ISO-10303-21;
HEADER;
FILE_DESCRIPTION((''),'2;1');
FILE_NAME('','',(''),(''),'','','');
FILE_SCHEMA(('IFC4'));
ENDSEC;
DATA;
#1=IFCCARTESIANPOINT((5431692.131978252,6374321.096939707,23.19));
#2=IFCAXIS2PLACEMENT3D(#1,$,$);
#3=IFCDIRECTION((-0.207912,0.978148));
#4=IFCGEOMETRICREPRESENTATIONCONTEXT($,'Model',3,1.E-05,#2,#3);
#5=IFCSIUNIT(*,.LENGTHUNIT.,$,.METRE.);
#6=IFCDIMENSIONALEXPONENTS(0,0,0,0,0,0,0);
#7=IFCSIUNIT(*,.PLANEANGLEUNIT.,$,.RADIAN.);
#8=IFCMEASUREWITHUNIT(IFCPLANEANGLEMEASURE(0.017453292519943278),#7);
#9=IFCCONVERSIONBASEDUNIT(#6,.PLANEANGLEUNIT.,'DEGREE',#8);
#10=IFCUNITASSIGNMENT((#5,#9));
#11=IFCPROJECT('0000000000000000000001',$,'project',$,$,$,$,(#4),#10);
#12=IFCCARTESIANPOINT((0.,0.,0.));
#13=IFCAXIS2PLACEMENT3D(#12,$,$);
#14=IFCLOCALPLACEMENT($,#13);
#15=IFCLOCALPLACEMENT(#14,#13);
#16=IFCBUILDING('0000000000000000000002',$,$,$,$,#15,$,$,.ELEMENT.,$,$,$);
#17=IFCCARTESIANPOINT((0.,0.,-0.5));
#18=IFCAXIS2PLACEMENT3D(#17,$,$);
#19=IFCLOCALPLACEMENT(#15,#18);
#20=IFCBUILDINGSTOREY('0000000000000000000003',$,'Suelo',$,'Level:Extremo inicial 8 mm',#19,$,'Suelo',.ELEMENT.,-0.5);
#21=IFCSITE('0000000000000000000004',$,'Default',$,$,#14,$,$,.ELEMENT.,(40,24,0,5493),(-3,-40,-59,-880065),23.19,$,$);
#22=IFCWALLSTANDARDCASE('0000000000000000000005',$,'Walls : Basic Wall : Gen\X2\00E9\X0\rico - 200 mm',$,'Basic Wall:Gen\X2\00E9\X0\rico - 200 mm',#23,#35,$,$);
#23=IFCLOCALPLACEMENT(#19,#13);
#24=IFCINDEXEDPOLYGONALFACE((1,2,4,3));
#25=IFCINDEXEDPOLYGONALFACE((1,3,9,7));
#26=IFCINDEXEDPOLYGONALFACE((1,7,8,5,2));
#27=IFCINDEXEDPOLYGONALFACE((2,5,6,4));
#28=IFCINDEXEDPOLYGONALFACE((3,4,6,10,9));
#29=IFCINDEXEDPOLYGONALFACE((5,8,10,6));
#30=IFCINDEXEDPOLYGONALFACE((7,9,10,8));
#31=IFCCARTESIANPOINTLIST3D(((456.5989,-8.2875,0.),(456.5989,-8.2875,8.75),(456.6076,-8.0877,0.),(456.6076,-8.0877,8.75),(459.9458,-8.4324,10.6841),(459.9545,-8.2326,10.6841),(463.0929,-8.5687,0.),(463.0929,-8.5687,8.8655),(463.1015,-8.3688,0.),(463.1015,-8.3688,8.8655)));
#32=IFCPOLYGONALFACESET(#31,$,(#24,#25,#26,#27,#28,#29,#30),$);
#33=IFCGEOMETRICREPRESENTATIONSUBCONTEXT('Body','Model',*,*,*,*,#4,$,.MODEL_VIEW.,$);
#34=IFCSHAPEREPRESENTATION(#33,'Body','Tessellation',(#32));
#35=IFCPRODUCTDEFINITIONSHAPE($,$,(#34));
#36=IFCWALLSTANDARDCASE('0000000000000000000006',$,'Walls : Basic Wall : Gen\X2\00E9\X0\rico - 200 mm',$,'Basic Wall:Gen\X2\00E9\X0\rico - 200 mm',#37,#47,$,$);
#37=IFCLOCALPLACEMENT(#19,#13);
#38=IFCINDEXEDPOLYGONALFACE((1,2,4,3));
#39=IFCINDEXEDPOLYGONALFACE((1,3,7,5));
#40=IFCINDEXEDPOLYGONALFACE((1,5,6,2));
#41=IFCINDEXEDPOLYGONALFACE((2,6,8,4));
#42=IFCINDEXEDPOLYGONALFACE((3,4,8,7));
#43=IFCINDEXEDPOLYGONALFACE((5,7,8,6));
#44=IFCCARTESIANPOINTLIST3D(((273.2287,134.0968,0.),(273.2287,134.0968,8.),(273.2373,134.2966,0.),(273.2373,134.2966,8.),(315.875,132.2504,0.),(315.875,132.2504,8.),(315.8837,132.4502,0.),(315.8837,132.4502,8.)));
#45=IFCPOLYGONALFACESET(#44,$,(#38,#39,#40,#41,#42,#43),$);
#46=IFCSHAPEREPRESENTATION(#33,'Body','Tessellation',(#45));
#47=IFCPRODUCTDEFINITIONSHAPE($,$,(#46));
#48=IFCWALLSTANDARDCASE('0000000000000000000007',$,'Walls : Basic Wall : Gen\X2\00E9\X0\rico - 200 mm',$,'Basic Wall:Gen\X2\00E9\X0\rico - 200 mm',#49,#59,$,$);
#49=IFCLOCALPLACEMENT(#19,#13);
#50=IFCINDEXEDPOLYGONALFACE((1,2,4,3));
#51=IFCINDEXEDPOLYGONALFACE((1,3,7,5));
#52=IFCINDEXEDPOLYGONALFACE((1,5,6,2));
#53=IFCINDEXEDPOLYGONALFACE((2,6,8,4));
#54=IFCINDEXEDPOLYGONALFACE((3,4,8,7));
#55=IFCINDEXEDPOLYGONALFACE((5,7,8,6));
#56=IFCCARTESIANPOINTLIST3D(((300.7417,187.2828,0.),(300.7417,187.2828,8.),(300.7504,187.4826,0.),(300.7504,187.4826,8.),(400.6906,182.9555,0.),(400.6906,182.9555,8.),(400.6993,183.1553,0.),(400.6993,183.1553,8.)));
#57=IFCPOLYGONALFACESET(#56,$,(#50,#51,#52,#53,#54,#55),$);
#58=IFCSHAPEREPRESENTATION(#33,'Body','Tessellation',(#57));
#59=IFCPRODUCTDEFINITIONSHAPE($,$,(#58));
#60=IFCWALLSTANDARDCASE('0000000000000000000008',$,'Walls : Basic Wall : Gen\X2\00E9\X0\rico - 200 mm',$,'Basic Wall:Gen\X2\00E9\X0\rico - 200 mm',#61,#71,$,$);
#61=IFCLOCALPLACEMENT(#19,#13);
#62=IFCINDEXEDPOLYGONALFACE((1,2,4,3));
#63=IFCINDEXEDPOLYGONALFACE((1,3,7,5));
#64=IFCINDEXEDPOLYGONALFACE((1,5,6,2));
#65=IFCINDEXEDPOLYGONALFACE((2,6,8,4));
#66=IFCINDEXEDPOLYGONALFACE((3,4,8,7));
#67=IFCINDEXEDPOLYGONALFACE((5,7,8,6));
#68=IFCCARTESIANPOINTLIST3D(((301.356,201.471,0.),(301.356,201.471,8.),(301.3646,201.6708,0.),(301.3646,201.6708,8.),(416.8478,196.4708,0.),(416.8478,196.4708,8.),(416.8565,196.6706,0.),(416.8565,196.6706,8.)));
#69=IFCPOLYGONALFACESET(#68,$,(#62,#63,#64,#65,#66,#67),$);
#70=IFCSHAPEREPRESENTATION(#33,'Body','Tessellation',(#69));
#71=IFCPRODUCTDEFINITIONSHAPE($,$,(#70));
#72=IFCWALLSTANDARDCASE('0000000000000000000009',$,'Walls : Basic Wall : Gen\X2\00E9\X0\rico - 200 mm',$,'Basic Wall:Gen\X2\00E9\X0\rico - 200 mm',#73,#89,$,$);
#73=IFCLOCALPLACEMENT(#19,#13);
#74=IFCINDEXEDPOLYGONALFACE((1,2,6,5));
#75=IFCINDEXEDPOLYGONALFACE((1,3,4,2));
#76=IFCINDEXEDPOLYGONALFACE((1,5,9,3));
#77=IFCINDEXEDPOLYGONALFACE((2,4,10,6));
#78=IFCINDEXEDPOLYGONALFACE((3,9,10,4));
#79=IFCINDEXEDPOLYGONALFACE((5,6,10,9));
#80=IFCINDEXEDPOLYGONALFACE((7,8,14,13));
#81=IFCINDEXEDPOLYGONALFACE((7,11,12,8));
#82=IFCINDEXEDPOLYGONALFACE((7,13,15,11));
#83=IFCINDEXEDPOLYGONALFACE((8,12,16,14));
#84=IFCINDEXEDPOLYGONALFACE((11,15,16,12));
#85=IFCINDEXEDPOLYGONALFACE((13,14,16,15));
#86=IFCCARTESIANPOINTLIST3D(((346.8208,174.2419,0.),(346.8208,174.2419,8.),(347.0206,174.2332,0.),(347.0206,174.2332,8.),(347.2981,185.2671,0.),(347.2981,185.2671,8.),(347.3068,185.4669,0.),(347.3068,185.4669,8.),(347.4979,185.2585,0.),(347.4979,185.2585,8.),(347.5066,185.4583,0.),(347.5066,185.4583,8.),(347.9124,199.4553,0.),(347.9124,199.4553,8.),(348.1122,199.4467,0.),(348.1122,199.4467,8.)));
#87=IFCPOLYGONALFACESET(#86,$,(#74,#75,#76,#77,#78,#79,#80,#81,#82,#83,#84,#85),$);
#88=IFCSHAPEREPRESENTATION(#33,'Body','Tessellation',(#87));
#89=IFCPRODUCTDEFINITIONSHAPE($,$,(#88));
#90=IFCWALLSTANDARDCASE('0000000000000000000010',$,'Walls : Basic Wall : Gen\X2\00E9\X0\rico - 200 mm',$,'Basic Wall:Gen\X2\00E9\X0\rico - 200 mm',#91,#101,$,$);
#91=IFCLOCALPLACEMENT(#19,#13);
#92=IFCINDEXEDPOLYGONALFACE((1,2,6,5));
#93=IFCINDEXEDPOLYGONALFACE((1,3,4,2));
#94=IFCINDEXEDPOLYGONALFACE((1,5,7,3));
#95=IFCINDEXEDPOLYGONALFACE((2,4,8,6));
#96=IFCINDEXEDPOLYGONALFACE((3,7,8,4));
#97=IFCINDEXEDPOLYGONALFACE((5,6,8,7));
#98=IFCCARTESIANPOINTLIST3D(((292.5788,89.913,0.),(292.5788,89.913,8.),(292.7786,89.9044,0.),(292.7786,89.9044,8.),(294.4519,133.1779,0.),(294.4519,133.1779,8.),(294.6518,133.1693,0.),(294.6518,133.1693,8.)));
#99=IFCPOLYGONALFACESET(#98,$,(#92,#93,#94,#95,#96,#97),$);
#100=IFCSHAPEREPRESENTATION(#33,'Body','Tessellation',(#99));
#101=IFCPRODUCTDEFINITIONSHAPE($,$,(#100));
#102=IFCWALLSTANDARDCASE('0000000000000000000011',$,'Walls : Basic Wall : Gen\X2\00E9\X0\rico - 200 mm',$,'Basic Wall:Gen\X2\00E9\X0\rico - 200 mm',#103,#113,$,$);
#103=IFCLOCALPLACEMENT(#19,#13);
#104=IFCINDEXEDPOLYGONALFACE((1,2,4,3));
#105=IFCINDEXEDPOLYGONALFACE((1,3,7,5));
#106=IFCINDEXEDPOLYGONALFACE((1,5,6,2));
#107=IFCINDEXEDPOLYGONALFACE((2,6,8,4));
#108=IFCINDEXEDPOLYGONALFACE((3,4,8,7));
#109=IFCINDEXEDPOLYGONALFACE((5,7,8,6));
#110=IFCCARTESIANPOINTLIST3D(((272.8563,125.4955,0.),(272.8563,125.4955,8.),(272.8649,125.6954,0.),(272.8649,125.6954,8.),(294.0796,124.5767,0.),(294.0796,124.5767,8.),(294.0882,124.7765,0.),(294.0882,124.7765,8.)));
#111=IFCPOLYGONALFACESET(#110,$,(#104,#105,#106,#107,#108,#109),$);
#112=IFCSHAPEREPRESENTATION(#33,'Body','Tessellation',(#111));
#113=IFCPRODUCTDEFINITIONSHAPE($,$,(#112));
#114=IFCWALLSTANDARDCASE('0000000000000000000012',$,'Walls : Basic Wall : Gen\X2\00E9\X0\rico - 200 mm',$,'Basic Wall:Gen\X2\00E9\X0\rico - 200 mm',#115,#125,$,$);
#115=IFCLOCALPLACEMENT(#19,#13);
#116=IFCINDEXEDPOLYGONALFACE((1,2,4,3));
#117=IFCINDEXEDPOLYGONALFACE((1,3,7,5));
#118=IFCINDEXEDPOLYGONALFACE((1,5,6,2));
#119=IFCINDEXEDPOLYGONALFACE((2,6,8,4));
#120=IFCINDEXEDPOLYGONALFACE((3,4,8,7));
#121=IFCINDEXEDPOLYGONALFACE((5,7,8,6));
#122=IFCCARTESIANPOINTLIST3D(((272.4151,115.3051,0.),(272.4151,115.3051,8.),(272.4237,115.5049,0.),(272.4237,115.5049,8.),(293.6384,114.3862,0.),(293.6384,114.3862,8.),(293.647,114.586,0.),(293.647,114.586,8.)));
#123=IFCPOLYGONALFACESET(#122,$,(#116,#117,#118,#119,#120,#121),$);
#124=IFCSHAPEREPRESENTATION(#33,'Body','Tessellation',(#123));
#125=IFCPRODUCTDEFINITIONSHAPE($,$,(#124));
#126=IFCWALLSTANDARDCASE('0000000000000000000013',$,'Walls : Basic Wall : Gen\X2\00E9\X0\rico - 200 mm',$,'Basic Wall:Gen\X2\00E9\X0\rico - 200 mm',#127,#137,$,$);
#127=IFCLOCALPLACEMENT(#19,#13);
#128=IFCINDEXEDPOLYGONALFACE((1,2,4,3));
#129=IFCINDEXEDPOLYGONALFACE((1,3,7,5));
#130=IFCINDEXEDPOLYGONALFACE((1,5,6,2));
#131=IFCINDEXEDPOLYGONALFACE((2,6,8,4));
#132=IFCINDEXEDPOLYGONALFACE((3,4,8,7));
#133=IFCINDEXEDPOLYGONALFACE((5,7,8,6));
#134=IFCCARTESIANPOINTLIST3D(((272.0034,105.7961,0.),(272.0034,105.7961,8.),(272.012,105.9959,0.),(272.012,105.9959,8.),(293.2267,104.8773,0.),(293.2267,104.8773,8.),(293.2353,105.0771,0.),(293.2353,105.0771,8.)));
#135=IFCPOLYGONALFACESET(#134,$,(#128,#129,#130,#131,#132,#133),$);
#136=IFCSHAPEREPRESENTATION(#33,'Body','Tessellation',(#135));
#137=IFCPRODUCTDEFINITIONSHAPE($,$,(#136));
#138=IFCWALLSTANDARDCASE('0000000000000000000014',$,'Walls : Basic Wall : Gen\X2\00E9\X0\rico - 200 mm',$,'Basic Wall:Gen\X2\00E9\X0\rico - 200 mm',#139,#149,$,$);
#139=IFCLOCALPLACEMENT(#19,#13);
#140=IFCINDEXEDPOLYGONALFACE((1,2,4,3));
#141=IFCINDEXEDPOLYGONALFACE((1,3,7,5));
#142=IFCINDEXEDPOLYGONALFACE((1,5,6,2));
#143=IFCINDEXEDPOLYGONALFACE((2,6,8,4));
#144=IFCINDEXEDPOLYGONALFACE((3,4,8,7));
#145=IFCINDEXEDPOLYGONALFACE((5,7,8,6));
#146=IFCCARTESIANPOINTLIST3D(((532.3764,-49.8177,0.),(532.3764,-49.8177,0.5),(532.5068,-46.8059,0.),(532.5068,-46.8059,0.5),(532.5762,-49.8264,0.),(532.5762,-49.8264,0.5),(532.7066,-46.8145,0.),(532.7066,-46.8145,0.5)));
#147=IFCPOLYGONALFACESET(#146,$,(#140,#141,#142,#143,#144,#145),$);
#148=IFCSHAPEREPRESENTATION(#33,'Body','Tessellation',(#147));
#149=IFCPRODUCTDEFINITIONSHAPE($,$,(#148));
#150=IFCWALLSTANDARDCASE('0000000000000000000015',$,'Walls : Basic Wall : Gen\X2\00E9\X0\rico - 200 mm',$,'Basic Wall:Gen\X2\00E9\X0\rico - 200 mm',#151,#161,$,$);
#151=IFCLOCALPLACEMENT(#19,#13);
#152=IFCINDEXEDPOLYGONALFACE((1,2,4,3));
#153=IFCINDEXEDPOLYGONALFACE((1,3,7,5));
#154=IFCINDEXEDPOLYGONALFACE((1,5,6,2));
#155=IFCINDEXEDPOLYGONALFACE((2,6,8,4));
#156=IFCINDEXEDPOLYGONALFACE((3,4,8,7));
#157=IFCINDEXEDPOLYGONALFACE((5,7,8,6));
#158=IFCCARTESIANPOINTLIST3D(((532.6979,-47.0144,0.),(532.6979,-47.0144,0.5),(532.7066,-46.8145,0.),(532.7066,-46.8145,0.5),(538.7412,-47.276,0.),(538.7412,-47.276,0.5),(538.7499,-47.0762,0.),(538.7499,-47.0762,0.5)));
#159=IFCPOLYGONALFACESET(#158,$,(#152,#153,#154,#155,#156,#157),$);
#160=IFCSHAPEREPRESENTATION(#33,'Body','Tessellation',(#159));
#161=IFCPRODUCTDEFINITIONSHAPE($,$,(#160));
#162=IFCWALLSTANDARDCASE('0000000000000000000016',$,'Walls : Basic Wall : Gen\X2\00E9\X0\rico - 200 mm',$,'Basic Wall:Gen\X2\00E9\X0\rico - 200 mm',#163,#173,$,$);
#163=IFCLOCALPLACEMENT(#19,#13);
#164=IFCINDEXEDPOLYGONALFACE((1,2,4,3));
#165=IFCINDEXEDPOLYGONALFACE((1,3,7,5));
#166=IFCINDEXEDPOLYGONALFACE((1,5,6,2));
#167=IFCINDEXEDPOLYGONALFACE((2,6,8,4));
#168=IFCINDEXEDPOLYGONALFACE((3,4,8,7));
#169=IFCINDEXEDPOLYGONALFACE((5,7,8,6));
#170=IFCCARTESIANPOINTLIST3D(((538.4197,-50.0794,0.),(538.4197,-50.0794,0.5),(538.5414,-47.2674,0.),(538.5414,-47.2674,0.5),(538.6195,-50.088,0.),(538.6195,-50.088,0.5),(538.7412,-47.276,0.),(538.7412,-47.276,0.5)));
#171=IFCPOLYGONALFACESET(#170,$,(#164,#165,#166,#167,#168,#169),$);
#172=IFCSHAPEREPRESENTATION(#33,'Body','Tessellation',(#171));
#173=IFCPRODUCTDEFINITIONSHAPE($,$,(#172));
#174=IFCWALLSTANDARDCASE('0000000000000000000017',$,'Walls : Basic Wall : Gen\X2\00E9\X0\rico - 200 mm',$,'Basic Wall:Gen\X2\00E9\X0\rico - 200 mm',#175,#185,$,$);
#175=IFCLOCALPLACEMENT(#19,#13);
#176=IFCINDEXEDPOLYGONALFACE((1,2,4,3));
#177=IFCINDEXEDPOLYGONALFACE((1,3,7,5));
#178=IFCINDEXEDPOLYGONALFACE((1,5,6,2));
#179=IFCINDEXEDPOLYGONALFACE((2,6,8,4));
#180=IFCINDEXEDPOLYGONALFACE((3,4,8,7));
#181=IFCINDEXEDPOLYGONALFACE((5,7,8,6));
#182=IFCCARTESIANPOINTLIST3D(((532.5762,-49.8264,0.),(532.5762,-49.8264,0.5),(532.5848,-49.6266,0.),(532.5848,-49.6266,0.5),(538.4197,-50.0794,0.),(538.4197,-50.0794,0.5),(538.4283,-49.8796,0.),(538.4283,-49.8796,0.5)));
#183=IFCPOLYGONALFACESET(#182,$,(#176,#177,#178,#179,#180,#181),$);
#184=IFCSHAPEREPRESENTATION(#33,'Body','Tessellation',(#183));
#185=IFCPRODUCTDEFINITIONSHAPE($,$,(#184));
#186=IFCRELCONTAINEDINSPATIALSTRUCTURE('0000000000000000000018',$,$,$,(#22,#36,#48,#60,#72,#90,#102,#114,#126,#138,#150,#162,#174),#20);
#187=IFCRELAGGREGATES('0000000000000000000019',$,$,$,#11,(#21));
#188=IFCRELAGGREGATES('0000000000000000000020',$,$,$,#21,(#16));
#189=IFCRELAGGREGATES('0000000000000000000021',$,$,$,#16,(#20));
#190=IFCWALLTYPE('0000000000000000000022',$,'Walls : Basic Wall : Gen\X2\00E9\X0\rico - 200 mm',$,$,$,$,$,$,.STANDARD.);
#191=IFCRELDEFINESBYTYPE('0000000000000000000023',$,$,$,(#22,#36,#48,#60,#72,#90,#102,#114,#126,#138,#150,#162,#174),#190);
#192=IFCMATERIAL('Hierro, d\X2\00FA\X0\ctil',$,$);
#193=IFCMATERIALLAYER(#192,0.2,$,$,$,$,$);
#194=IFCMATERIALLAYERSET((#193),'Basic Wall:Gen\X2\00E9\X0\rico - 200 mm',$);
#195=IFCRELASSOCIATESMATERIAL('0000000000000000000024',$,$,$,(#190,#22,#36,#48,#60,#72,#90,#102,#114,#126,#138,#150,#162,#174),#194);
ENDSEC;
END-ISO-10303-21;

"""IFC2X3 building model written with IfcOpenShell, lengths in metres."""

from ifc_helpers import new_model, entity, si_unit, converted_unit, direction, frame, frame_2d, origin, place, context, subcontext, project, spatial, polyline, rectangle, extrude, clip, bounded_halfspace, material, layer, layer_set, layer_usage, type_object, element, save


model = new_model("IFC2X3")

# Units and contexts
model_context = context("Model", 3, precision=1e-05, world=frame((5431692.131978252, 6374321.096939707, 23.19)), true_north=direction((-0.207912, 0.978148)))
body_context = subcontext(model_context, "Body", "Model", "MODEL_VIEW")
ifc_project = project(units=[si_unit("LENGTHUNIT", "METRE"), converted_unit("PLANEANGLEUNIT", "DEGREE", entity("IfcPlaneAngleMeasure", 0.017453292519943278), si_unit("PLANEANGLEUNIT", "RADIAN"), dimensions=[0, 0, 0, 0, 0, 0, 0])], contexts=[model_context])

# Site, building, storey
site_placement = place(None, origin())
site = spatial("IfcSite", under=ifc_project, at=site_placement, Name="Default", CompositionType="ELEMENT", RefLatitude=(40, 24, 0, 5493), RefLongitude=(-3, -40, -59, -880065), RefElevation=23.19)
building_placement = place(site_placement, origin())
building = spatial("IfcBuilding", under=site, at=building_placement, CompositionType="ELEMENT")
storey_placement = place(building_placement, frame((0.0, 0.0, -0.5)))
storey = spatial("IfcBuildingStorey", under=building, at=storey_placement, Name="Suelo", ObjectType="Level:Extremo inicial 8 mm", LongName="Suelo", CompositionType="ELEMENT", Elevation=-0.5)

# Walls
ifc_material_1 = material(Name="Hierro, dúctil")
ifc_layer_1 = layer(ifc_material_1, 0.2)
ifc_layer_set_1 = layer_set([ifc_layer_1], Name="Basic Wall:Genérico - 200 mm")
wall_type = type_object("IfcWallType", Name="Walls : Basic Wall : Genérico - 200 mm", PredefinedType="STANDARD", material=ifc_layer_set_1)
ifc_layer_usage_1 = layer_usage(ifc_layer_set_1, "AXIS2", "NEGATIVE", 0.1)
wall_1_placement = place(storey_placement, frame((463.0972, -8.4687, 0.0), z_axis=(0.0, 0.0, 1.0), x_axis=(-0.999064, 0.043255, 0.0)))
element("IfcWallStandardCase", 1, at=wall_1_placement, inside=storey, type_object=wall_type, material=ifc_layer_usage_1, Name="Walls : Basic Wall : Genérico - 200 mm", ObjectType="Basic Wall:Genérico - 200 mm", context=body_context, shape_type="Clipping", body=[
    clip(clip(extrude(rectangle(XDim=6.5, YDim=0.2, at=frame_2d((3.25, 0.0), x_axis=(-1.0, 0.0))), origin(), (0.0, 0.0, 1.0), 10.6841), bounded_halfspace(frame((0.0, -0.1, 8.8655), z_axis=(-0.5, 0.0, 0.866025), x_axis=(0.0, -1.0, 0.0)), False, frame((0.0, -0.1, 8.8655)), polyline([(0.0, 0.0), (3.15, 0.0), (3.15, 0.2), (0.0, 0.2), (0.0, 0.0)]))), bounded_halfspace(frame((3.15, -0.1, 10.6841), z_axis=(0.5, 0.0, 0.866025), x_axis=(0.0, 1.0, 0.0)), False, frame((3.15, -0.1, 10.6841)), polyline([(0.0, 0.0), (3.35, 0.0), (3.35, 0.2), (0.0, 0.2), (0.0, 0.0)]))),
])
ifc_layer_usage_2 = layer_usage(ifc_layer_set_1, "AXIS2", "NEGATIVE", 0.1)
wall_2_placement = place(storey_placement, frame((273.233, 134.1967, 0.0), z_axis=(0.0, 0.0, 1.0), x_axis=(0.999064, -0.043255, 0.0)))
element("IfcWallStandardCase", 2, at=wall_2_placement, inside=storey, type_object=wall_type, material=ifc_layer_usage_2, Name="Walls : Basic Wall : Genérico - 200 mm", ObjectType="Basic Wall:Genérico - 200 mm", context=body_context, shape_type="SweptSolid", body=[
    extrude(rectangle(XDim=42.6863, YDim=0.2, at=frame_2d((21.3432, 0.0), x_axis=(-1.0, 0.0))), origin(), (0.0, 0.0, 1.0), 8.0),
])
ifc_layer_usage_3 = layer_usage(ifc_layer_set_1, "AXIS2", "NEGATIVE", 0.1)
wall_3_placement = place(storey_placement, frame((400.6949, 183.0554, 0.0), z_axis=(0.0, 0.0, 1.0), x_axis=(-0.999064, 0.043255, 0.0)))
element("IfcWallStandardCase", 3, at=wall_3_placement, inside=storey, type_object=wall_type, material=ifc_layer_usage_3, Name="Walls : Basic Wall : Genérico - 200 mm", ObjectType="Basic Wall:Genérico - 200 mm", context=body_context, shape_type="SweptSolid", body=[
    extrude(rectangle(XDim=100.0425, YDim=0.2, at=frame_2d((50.0213, 0.0), x_axis=(-1.0, 0.0))), origin(), (0.0, 0.0, 1.0), 8.0),
])
ifc_layer_usage_4 = layer_usage(ifc_layer_set_1, "AXIS2", "NEGATIVE", 0.1)
wall_4_placement = place(storey_placement, frame((416.8521, 196.5707, 0.0), z_axis=(0.0, 0.0, 1.0), x_axis=(-0.999064, 0.043255, 0.0)))
element("IfcWallStandardCase", 4, at=wall_4_placement, inside=storey, type_object=wall_type, material=ifc_layer_usage_4, Name="Walls : Basic Wall : Genérico - 200 mm", ObjectType="Basic Wall:Genérico - 200 mm", context=body_context, shape_type="SweptSolid", body=[
    extrude(rectangle(XDim=115.6, YDim=0.2, at=frame_2d((57.8, 0.0), x_axis=(-1.0, 0.0))), origin(), (0.0, 0.0, 1.0), 8.0),
])

# Wall, opening
ifc_layer_usage_5 = layer_usage(ifc_layer_set_1, "AXIS2", "NEGATIVE", 0.1)
wall_5_placement = place(storey_placement, frame((346.9207, 174.2375, 0.0), z_axis=(0.0, 0.0, 1.0), x_axis=(0.043255, 0.999064, 0.0)))
wall_5 = element("IfcWallStandardCase", 5, at=wall_5_placement, inside=storey, type_object=wall_type, material=ifc_layer_usage_5, Name="Walls : Basic Wall : Genérico - 200 mm", ObjectType="Basic Wall:Genérico - 200 mm", context=body_context, shape_type="SweptSolid", body=[
    extrude(rectangle(XDim=25.2371, YDim=0.2, at=frame_2d((12.6185, 0.0), x_axis=(-1.0, 0.0))), origin(), (0.0, 0.0, 1.0), 8.0),
])
opening_placement = place(storey_placement, frame((346.9207, 174.2375, 0.0), z_axis=(0.0, 0.0, 1.0), x_axis=(0.043255, 0.999064, 0.0)))
element("IfcOpeningElement", 6, at=opening_placement, cuts=wall_5, ObjectType="Opening", context=body_context, shape_type="SweptSolid", body=[
    extrude(rectangle(XDim=8.0, YDim=0.2, at=frame_2d((0.0, 0.0), x_axis=(1.0, 0.0))), frame((11.0356, 0.0, 4.0), z_axis=(1.0, 0.0, 0.0), x_axis=(0.0, 0.0, -1.0)), (0.0, 0.0, 1.0), 0.2),
])

# Walls
ifc_layer_usage_6 = layer_usage(ifc_layer_set_1, "AXIS2", "NEGATIVE", 0.1)
wall_6_placement = place(storey_placement, frame((294.5519, 133.1736, 0.0), z_axis=(0.0, 0.0, 1.0), x_axis=(-0.043255, -0.999064, 0.0)))
element("IfcWallStandardCase", 7, at=wall_6_placement, inside=storey, type_object=wall_type, material=ifc_layer_usage_6, Name="Walls : Basic Wall : Genérico - 200 mm", ObjectType="Basic Wall:Genérico - 200 mm", context=body_context, shape_type="SweptSolid", body=[
    extrude(rectangle(XDim=43.3055, YDim=0.2, at=frame_2d((21.6527, 0.0), x_axis=(-1.0, 0.0))), origin(), (0.0, 0.0, 1.0), 8.0),
])
ifc_layer_usage_7 = layer_usage(ifc_layer_set_1, "AXIS2", "NEGATIVE", 0.1)
wall_7_placement = place(storey_placement, frame((272.8606, 125.5955, 0.0), z_axis=(0.0, 0.0, 1.0), x_axis=(0.999064, -0.043255, 0.0)))
element("IfcWallStandardCase", 8, at=wall_7_placement, inside=storey, type_object=wall_type, material=ifc_layer_usage_7, Name="Walls : Basic Wall : Genérico - 200 mm", ObjectType="Basic Wall:Genérico - 200 mm", context=body_context, shape_type="SweptSolid", body=[
    extrude(rectangle(XDim=21.2432, YDim=0.2, at=frame_2d((10.6216, 0.0), x_axis=(-1.0, 0.0))), origin(), (0.0, 0.0, 1.0), 8.0),
])
ifc_layer_usage_8 = layer_usage(ifc_layer_set_1, "AXIS2", "NEGATIVE", 0.1)
wall_8_placement = place(storey_placement, frame((272.4194, 115.405, 0.0), z_axis=(0.0, 0.0, 1.0), x_axis=(0.999064, -0.043255, 0.0)))
element("IfcWallStandardCase", 9, at=wall_8_placement, inside=storey, type_object=wall_type, material=ifc_layer_usage_8, Name="Walls : Basic Wall : Genérico - 200 mm", ObjectType="Basic Wall:Genérico - 200 mm", context=body_context, shape_type="SweptSolid", body=[
    extrude(rectangle(XDim=21.2432, YDim=0.2, at=frame_2d((10.6216, 0.0), x_axis=(-1.0, 0.0))), origin(), (0.0, 0.0, 1.0), 8.0),
])
ifc_layer_usage_9 = layer_usage(ifc_layer_set_1, "AXIS2", "NEGATIVE", 0.1)
wall_9_placement = place(storey_placement, frame((272.0077, 105.896, 0.0), z_axis=(0.0, 0.0, 1.0), x_axis=(0.999064, -0.043255, 0.0)))
element("IfcWallStandardCase", 10, at=wall_9_placement, inside=storey, type_object=wall_type, material=ifc_layer_usage_9, Name="Walls : Basic Wall : Genérico - 200 mm", ObjectType="Basic Wall:Genérico - 200 mm", context=body_context, shape_type="SweptSolid", body=[
    extrude(rectangle(XDim=21.2432, YDim=0.2, at=frame_2d((10.6216, 0.0), x_axis=(-1.0, 0.0))), origin(), (0.0, 0.0, 1.0), 8.0),
])
ifc_layer_usage_10 = layer_usage(ifc_layer_set_1, "AXIS2", "NEGATIVE", 0.1)
wall_10_placement = place(storey_placement, frame((532.4763, -49.8221, 0.0), z_axis=(0.0, 0.0, 1.0), x_axis=(0.043255, 0.999064, 0.0)))
element("IfcWallStandardCase", 11, at=wall_10_placement, inside=storey, type_object=wall_type, material=ifc_layer_usage_10, Name="Walls : Basic Wall : Genérico - 200 mm", ObjectType="Basic Wall:Genérico - 200 mm", context=body_context, shape_type="SweptSolid", body=[
    extrude(rectangle(XDim=3.0147, YDim=0.2, at=frame_2d((1.5073, 0.0), x_axis=(-1.0, 0.0))), origin(), (0.0, 0.0, 1.0), 0.5),
])
ifc_layer_usage_11 = layer_usage(ifc_layer_set_1, "AXIS2", "NEGATIVE", 0.1)
wall_11_placement = place(storey_placement, frame((532.7022, -46.9145, 0.0), z_axis=(0.0, 0.0, 1.0), x_axis=(0.999064, -0.043255, 0.0)))
element("IfcWallStandardCase", 12, at=wall_11_placement, inside=storey, type_object=wall_type, material=ifc_layer_usage_11, Name="Walls : Basic Wall : Genérico - 200 mm", ObjectType="Basic Wall:Genérico - 200 mm", context=body_context, shape_type="SweptSolid", body=[
    extrude(rectangle(XDim=6.049, YDim=0.2, at=frame_2d((3.0245, 0.0), x_axis=(-1.0, 0.0))), origin(), (0.0, 0.0, 1.0), 0.5),
])
ifc_layer_usage_12 = layer_usage(ifc_layer_set_1, "AXIS2", "NEGATIVE", 0.1)
wall_12_placement = place(storey_placement, frame((538.6413, -47.2717, 0.0), z_axis=(0.0, 0.0, 1.0), x_axis=(-0.043255, -0.999064, 0.0)))
element("IfcWallStandardCase", 13, at=wall_12_placement, inside=storey, type_object=wall_type, material=ifc_layer_usage_12, Name="Walls : Basic Wall : Genérico - 200 mm", ObjectType="Basic Wall:Genérico - 200 mm", context=body_context, shape_type="SweptSolid", body=[
    extrude(rectangle(XDim=2.8147, YDim=0.2, at=frame_2d((1.4073, 0.0), x_axis=(-1.0, 0.0))), origin(), (0.0, 0.0, 1.0), 0.5),
])
ifc_layer_usage_13 = layer_usage(ifc_layer_set_1, "AXIS2", "NEGATIVE", 0.1)
wall_13_placement = place(storey_placement, frame((538.424, -49.9795, 0.0), z_axis=(0.0, 0.0, 1.0), x_axis=(-0.999064, 0.043255, 0.0)))
element("IfcWallStandardCase", 14, at=wall_13_placement, inside=storey, type_object=wall_type, material=ifc_layer_usage_13, Name="Walls : Basic Wall : Genérico - 200 mm", ObjectType="Basic Wall:Genérico - 200 mm", context=body_context, shape_type="SweptSolid", body=[
    extrude(rectangle(XDim=5.849, YDim=0.2, at=frame_2d((2.9245, 0.0), x_axis=(-1.0, 0.0))), origin(), (0.0, 0.0, 1.0), 0.5),
])

save(model, "model.ifc")
